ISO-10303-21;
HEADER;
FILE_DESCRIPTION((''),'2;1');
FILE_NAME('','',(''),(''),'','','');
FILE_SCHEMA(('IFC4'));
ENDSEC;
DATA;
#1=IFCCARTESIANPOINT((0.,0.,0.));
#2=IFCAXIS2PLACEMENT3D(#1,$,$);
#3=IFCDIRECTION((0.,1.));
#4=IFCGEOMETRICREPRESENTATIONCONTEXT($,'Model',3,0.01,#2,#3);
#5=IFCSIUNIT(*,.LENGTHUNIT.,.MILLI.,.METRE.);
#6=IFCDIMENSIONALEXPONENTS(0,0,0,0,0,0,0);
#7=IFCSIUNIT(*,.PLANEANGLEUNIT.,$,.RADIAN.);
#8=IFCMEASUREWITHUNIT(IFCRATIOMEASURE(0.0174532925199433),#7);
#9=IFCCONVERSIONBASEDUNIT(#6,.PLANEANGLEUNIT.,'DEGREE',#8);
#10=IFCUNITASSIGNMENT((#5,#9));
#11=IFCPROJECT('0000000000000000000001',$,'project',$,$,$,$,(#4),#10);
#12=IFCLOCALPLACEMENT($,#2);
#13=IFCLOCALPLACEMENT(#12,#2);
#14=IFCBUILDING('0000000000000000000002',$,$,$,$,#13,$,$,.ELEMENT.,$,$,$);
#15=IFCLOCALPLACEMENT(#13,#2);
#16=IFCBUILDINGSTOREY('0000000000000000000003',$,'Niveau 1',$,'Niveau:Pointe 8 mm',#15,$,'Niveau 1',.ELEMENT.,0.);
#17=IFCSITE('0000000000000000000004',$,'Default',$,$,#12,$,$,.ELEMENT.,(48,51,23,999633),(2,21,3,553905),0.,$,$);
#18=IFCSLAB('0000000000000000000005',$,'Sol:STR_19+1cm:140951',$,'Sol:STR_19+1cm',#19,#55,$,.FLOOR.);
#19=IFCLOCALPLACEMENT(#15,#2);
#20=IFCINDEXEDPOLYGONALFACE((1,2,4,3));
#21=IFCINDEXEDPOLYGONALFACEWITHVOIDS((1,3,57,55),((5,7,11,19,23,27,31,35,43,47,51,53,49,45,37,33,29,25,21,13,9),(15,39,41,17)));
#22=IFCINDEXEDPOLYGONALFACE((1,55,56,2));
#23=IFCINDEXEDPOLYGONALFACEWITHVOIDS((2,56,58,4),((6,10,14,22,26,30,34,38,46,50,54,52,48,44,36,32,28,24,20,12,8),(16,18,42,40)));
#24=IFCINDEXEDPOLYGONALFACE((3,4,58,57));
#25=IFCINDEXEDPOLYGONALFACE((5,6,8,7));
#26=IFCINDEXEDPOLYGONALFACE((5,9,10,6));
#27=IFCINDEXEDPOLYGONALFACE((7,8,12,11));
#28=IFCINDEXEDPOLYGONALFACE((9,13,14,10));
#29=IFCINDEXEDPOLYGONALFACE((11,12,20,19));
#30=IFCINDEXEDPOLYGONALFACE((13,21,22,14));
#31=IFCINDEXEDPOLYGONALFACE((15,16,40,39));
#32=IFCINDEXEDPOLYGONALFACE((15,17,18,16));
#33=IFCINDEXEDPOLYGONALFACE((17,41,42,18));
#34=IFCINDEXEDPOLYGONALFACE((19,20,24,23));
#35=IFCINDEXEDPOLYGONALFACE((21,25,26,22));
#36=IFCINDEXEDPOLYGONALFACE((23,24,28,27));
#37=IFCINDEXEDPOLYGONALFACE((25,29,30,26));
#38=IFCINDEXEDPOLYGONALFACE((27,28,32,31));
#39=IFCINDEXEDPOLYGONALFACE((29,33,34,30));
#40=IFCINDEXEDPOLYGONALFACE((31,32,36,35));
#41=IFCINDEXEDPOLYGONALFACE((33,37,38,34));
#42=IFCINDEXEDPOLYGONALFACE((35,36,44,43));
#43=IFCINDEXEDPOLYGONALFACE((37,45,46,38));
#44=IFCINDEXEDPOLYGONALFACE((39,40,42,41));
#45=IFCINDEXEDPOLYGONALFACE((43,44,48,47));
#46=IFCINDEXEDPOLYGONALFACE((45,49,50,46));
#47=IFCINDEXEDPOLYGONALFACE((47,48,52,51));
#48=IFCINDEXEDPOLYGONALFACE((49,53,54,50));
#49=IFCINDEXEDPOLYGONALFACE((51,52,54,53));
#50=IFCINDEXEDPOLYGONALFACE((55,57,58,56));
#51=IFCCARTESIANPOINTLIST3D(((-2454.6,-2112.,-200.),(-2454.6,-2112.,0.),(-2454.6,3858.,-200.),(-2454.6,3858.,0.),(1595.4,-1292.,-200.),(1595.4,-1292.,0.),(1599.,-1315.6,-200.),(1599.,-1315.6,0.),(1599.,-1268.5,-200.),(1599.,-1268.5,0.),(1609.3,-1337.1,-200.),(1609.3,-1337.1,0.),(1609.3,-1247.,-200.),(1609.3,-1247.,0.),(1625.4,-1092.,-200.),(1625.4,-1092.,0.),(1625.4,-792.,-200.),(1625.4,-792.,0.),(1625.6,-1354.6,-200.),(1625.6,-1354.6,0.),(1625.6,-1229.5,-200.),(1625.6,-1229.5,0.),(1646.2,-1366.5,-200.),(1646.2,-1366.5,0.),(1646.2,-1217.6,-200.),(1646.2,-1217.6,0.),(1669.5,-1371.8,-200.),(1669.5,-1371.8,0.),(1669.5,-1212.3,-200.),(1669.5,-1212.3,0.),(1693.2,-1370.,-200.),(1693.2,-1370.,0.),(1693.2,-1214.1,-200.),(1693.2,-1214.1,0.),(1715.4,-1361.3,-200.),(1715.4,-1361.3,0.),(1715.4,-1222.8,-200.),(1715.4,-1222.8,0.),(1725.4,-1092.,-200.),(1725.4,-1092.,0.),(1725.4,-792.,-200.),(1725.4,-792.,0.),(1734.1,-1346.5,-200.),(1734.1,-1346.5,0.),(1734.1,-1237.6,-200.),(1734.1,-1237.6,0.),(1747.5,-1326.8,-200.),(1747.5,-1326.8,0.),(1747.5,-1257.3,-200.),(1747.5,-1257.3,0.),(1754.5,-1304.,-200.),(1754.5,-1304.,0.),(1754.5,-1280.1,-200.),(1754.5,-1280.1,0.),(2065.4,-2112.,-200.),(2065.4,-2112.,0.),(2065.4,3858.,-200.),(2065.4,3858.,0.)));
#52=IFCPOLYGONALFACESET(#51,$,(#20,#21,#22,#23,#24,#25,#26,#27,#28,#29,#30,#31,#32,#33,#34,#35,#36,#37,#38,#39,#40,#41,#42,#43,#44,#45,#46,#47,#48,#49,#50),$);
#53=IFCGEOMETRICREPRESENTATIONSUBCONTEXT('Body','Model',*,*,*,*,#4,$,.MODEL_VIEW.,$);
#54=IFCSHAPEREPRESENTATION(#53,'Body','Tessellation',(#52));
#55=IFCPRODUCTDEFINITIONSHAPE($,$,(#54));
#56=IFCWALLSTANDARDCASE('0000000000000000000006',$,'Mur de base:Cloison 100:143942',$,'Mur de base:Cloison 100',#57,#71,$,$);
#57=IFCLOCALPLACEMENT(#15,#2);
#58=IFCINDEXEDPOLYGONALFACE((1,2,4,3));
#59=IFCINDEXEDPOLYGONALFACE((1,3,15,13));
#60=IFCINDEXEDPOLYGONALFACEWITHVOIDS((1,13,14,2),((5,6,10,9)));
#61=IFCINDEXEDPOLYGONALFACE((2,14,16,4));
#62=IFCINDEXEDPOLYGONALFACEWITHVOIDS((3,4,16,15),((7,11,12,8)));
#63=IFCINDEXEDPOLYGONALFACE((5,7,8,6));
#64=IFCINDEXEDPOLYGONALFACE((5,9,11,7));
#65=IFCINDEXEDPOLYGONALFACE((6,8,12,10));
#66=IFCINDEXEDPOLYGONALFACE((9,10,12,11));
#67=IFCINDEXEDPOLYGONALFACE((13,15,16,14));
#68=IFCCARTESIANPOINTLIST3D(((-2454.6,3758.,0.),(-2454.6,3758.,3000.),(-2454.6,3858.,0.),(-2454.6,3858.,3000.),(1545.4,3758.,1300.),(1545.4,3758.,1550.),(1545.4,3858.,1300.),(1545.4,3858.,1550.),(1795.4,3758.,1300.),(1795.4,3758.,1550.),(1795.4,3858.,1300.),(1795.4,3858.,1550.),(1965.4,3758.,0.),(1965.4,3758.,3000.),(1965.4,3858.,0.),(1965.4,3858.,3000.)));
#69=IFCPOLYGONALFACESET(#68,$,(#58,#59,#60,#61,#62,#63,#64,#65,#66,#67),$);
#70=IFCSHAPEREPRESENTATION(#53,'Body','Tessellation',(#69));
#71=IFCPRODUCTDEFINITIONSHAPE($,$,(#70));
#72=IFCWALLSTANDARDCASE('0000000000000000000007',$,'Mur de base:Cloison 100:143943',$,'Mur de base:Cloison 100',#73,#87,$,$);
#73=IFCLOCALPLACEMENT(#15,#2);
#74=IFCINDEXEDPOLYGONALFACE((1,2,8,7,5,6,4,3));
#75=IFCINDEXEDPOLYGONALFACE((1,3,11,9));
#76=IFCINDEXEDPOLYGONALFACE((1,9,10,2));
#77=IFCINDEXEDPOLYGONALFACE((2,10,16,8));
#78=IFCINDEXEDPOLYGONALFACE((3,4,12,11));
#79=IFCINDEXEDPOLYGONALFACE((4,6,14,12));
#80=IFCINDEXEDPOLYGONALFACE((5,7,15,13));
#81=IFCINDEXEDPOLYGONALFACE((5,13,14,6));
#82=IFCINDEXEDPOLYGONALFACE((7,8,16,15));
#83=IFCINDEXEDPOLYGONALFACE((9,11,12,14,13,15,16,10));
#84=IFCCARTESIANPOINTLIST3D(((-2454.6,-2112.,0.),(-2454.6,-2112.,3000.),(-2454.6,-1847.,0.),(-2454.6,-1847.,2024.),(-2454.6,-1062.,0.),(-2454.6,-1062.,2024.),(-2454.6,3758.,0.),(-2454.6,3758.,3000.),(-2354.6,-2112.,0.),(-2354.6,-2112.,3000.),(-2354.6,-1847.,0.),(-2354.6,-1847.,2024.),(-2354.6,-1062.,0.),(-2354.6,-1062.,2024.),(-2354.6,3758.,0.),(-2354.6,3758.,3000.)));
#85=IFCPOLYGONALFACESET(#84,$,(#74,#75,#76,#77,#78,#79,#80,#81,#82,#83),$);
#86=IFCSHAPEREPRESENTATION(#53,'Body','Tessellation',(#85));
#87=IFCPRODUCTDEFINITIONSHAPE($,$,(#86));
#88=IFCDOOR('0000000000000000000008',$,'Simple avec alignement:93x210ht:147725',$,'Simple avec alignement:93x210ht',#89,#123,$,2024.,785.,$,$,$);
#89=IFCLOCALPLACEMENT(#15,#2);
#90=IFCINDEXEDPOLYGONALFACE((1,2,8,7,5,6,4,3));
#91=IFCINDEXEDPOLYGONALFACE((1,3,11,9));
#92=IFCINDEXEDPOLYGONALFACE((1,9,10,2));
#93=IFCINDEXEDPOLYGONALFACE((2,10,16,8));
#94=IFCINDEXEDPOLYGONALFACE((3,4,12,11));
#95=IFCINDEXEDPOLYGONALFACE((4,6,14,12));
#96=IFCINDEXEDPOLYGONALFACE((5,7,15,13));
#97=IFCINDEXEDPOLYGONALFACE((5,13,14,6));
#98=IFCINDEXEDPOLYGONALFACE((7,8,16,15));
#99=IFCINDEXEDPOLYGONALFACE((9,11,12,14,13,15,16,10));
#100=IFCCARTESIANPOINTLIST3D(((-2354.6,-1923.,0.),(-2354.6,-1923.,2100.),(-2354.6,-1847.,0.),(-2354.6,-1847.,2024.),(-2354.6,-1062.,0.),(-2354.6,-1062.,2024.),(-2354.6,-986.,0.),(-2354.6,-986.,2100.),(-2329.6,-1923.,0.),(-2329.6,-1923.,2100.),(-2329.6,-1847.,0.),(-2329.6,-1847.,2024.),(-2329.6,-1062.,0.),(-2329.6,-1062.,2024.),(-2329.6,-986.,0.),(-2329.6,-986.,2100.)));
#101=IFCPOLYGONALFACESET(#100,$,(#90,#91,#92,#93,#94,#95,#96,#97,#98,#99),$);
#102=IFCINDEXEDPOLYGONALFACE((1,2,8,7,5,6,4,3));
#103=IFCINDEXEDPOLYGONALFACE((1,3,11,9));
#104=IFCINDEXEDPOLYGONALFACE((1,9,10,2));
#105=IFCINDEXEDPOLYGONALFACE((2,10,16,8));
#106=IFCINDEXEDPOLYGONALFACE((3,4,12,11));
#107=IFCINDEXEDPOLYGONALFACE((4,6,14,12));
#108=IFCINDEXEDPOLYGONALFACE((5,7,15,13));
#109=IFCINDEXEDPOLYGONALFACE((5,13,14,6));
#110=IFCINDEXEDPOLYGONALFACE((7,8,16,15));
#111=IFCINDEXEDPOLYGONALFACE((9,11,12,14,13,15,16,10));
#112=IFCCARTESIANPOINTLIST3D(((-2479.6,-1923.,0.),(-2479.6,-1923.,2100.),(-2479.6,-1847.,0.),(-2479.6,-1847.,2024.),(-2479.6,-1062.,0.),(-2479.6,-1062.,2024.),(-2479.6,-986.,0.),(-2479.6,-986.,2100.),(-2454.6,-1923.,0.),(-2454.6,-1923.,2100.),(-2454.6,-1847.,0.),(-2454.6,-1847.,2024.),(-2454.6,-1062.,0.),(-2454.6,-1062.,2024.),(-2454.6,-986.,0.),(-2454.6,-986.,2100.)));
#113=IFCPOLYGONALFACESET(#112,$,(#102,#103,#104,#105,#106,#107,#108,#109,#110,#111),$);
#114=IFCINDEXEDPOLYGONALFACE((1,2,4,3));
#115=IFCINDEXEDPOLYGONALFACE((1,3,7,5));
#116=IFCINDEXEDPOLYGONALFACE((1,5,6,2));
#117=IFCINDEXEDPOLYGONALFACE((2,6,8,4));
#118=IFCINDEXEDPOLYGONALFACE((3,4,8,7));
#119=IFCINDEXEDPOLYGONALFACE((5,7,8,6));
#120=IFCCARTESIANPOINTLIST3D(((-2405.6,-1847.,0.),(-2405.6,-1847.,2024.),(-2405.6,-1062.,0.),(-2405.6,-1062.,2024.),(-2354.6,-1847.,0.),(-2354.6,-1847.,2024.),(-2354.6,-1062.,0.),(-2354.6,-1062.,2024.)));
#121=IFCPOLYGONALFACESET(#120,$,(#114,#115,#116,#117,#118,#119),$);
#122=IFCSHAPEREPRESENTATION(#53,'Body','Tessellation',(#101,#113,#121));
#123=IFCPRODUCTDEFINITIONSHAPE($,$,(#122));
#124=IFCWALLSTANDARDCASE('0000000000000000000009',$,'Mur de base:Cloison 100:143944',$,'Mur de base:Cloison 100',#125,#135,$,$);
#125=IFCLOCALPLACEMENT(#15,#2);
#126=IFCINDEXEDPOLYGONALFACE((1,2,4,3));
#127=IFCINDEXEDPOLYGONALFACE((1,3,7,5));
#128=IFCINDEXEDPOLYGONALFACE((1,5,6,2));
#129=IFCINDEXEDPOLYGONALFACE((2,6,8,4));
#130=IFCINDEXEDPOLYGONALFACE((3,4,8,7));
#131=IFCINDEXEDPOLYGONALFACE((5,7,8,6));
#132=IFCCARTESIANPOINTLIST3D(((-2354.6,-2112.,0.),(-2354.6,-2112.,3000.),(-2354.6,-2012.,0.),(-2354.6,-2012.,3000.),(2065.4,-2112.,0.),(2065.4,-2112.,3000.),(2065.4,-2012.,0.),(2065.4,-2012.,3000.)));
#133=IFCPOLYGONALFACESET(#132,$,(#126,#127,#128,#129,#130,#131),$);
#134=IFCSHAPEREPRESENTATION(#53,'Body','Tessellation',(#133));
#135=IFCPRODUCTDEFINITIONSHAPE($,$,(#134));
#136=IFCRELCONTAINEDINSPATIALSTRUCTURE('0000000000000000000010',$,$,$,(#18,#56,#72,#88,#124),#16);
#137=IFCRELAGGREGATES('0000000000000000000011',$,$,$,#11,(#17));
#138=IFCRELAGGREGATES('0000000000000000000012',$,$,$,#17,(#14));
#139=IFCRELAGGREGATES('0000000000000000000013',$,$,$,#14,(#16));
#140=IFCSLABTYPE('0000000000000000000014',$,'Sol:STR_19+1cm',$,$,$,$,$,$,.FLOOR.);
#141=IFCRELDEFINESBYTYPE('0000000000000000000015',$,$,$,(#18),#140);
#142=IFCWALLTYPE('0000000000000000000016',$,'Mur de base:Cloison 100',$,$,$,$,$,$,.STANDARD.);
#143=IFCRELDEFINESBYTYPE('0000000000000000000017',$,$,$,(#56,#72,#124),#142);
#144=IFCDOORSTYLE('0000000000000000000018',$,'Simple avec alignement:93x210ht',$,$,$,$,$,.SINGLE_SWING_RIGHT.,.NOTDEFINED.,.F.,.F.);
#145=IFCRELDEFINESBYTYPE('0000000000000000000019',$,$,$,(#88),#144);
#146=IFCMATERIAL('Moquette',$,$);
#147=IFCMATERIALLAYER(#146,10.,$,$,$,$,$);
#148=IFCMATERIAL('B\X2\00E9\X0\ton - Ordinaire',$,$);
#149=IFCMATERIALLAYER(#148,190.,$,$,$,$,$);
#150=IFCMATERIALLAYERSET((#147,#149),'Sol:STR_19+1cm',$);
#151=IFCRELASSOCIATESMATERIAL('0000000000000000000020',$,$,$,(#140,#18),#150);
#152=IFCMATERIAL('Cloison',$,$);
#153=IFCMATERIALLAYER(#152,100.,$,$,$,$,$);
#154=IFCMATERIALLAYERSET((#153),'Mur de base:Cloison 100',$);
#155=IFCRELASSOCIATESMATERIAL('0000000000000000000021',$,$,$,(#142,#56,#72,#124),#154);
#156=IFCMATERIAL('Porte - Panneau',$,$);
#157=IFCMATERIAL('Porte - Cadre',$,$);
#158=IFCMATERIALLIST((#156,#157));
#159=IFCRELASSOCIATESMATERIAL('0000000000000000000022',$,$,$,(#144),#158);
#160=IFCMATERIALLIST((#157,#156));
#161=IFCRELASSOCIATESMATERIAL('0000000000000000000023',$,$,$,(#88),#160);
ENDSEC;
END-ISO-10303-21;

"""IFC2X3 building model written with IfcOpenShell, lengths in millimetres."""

from ifc_helpers import new_model, entity, si_unit, converted_unit, direction, frame, frame_2d, origin, origin_2d_with_axis, place, context, subcontext, project, spatial, polyline, rectangle, circle, outline, extrude, source, transform, mapped, material, material_list, layer, layer_set, layer_usage, type_object, type_shapes, element, fill, save


model = new_model("IFC2X3")

# Units and contexts
model_context = context("Model", 3, precision=0.01, world=origin(), true_north=direction((0.0, 1.0)))
body_context = subcontext(model_context, "Body", "Model", "MODEL_VIEW")
ifc_project = project(units=[si_unit("LENGTHUNIT", "METRE", prefix="MILLI"), converted_unit("PLANEANGLEUNIT", "DEGREE", entity("IfcRatioMeasure", 0.0174532925199433), si_unit("PLANEANGLEUNIT", "RADIAN"), dimensions=[0, 0, 0, 0, 0, 0, 0])], contexts=[model_context])

# Site, building, storey
site_placement = place(None, origin())
site = spatial("IfcSite", under=ifc_project, at=site_placement, Name="Default", CompositionType="ELEMENT", RefLatitude=(48, 51, 23, 999633), RefLongitude=(2, 21, 3, 553905), RefElevation=0.0)
building_placement = place(site_placement, origin())
building = spatial("IfcBuilding", under=site, at=building_placement, CompositionType="ELEMENT")
storey_placement = place(building_placement, origin())
storey = spatial("IfcBuildingStorey", under=building, at=storey_placement, Name="Niveau 1", ObjectType="Niveau:Pointe 8 mm", LongName="Niveau 1", CompositionType="ELEMENT", Elevation=0.0)

# Slab, openings
ifc_material_1 = material(Name="Moquette")
ifc_layer_1 = layer(ifc_material_1, 10.0)
ifc_material_2 = material(Name="Béton - Ordinaire")
ifc_layer_2 = layer(ifc_material_2, 190.0)
ifc_layer_set_1 = layer_set([ifc_layer_1, ifc_layer_2], Name="Sol:STR_19+1cm")
ifc_layer_usage_1 = layer_usage(ifc_layer_set_1, "AXIS3", "POSITIVE", 0.0)
slab_type = type_object("IfcSlabType", Name="Sol:STR_19+1cm", PredefinedType="FLOOR", material=ifc_layer_set_1)
slab_placement = place(storey_placement, origin())
slab = element("IfcSlab", 1, at=slab_placement, inside=storey, type_object=slab_type, material=ifc_layer_usage_1, Name="Sol:STR_19+1cm:140951", ObjectType="Sol:STR_19+1cm", PredefinedType="FLOOR", context=body_context, shape_type="SweptSolid", body=[
    extrude(rectangle(XDim=4520.0, YDim=5970.0, at=origin_2d_with_axis()), frame((-194.6, 873.0, 0.0), z_axis=(0.0, 0.0, -1.0), x_axis=(-1.0, 0.0, 0.0)), (0.0, 0.0, 1.0), 200.0),
])
opening_1_placement = place(slab_placement, origin())
element("IfcOpeningElement", 2, at=opening_1_placement, cuts=slab, ObjectType="Opening", context=body_context, shape_type="SweptSolid", body=[
    extrude(circle(Radius=80.0, at=origin_2d_with_axis()), frame((1675.4, -1292.0, -1524.0), z_axis=(0.0, 0.0, 1.0), x_axis=(-1.0, 0.0, 0.0)), (0.0, 0.0, 1.0), 3048.0),
])
opening_2_placement = place(slab_placement, origin())
element("IfcOpeningElement", 3, at=opening_2_placement, cuts=slab, ObjectType="Opening", context=body_context, shape_type="SweptSolid", body=[
    extrude(rectangle(XDim=300.0, YDim=100.0, at=origin_2d_with_axis()), frame((1675.4, -942.0, -1524.0), z_axis=(0.0, 0.0, 1.0), x_axis=(0.0, 1.0, 0.0)), (0.0, 0.0, 1.0), 3048.0),
])

# Wall, opening
ifc_material_3 = material(Name="Cloison")
ifc_layer_3 = layer(ifc_material_3, 100.0)
ifc_layer_set_2 = layer_set([ifc_layer_3], Name="Mur de base:Cloison 100")
ifc_layer_usage_2 = layer_usage(ifc_layer_set_2, "AXIS2", "NEGATIVE", 50.0)
wall_type = type_object("IfcWallType", Name="Mur de base:Cloison 100", PredefinedType="STANDARD", material=ifc_layer_set_2)
wall_1_placement = place(storey_placement, frame((-2454.6, 3808.0, 0.0)))
wall_1 = element("IfcWallStandardCase", 4, at=wall_1_placement, inside=storey, type_object=wall_type, material=ifc_layer_usage_2, Name="Mur de base:Cloison 100:143942", ObjectType="Mur de base:Cloison 100", context=body_context, shape_type="SweptSolid", body=[
    extrude(rectangle(XDim=4420.0, YDim=100.0, at=frame_2d((2210.0, 0.0), x_axis=(-1.0, 0.0))), origin(), (0.0, 0.0, 1.0), 3000.0),
])
opening_3_placement = place(wall_1_placement, origin())
element("IfcOpeningElement", 5, at=opening_3_placement, cuts=wall_1, ObjectType="Opening", context=body_context, shape_type="SweptSolid", body=[
    extrude(rectangle(XDim=250.0, YDim=250.0, at=origin_2d_with_axis()), frame((4125.0, -1574.0, 1425.0), z_axis=(0.0, 1.0, 0.0), x_axis=(0.0, 0.0, 1.0)), (0.0, 0.0, 1.0), 3048.0),
])

# Wall, opening, door
ifc_layer_usage_3 = layer_usage(ifc_layer_set_2, "AXIS2", "NEGATIVE", 50.0)
wall_2_placement = place(storey_placement, frame((-2404.6, -2112.0, 0.0), z_axis=(0.0, 0.0, 1.0), x_axis=(0.0, 1.0, 0.0)))
wall_2 = element("IfcWallStandardCase", 6, at=wall_2_placement, inside=storey, type_object=wall_type, material=ifc_layer_usage_3, Name="Mur de base:Cloison 100:143943", ObjectType="Mur de base:Cloison 100", context=body_context, shape_type="SweptSolid", body=[
    extrude(rectangle(XDim=5870.0, YDim=100.0, at=frame_2d((2935.0, 0.0), x_axis=(-1.0, 0.0))), origin(), (0.0, 0.0, 1.0), 3000.0),
])
opening_4_placement = place(wall_2_placement, frame((1050.0, 50.0, 0.0)))
opening_4 = element("IfcOpeningElement", 7, at=opening_4_placement, cuts=wall_2, ObjectType="Opening", context=body_context, shape_type="SweptSolid", body=[
    extrude(rectangle(XDim=785.0, YDim=2024.0, at=frame_2d((1012.0, 392.5), x_axis=(0.0, 1.0))), frame((0.0, 0.0, 0.0), z_axis=(0.0, -1.0, 0.0), x_axis=(0.0, 0.0, 1.0)), (0.0, 0.0, 1.0), 100.0),
])
ifc_material_4 = material(Name="Porte - Cadre")
ifc_material_5 = material(Name="Porte - Panneau")
ifc_material_list_1 = material_list([ifc_material_4, ifc_material_5])
ifc_material_list_2 = material_list([ifc_material_5, ifc_material_4])
door_style = type_object("IfcDoorStyle", Name="Simple avec alignement:93x210ht", ConstructionType="NOTDEFINED", OperationType="SINGLE_SWING_RIGHT", ParameterTakesPrecedence=False, Sizeable=False, material=ifc_material_list_2)
shared_shape_1 = source(origin(), body_context, "Body", "SweptSolid", [
    extrude(outline(polyline([(-468.5, -1069.0), (468.5, -1069.0), (468.5, 1031.0), (392.5, 1031.0), (392.5, -993.0), (-392.5, -993.0), (-392.5, 1031.0), (-468.5, 1031.0), (-468.5, -1069.0)])), frame((392.5, 100.0, 1031.0), z_axis=(0.0, 1.0, 0.0), x_axis=(1.0, 0.0, 0.0)), (0.0, 0.0, 1.0), 25.0),
    extrude(outline(polyline([(-1069.0, -468.5), (1031.0, -468.5), (1031.0, -392.5), (-993.0, -392.5), (-993.0, 392.5), (1031.0, 392.5), (1031.0, 468.5), (-1069.0, 468.5), (-1069.0, -468.5)])), frame((392.5, -25.0, 1031.0), z_axis=(0.0, 1.0, 0.0), x_axis=(0.0, 0.0, -1.0)), (0.0, 0.0, 1.0), 25.0),
    extrude(rectangle(XDim=51.0, YDim=785.0, at=origin_2d_with_axis()), frame((392.5, 74.5, 0.0), z_axis=(0.0, 0.0, 1.0), x_axis=(0.0, 1.0, 0.0)), (0.0, 0.0, 1.0), 2024.0),
])
type_shapes(door_style, [shared_shape_1])
door_placement = place(opening_4_placement, frame((0.0, 0.0, 0.0), z_axis=(0.0, 0.0, 1.0), x_axis=(-1.0, 0.0, 0.0)))
door = element("IfcDoor", 8, at=door_placement, inside=storey, type_object=door_style, material=ifc_material_list_1, Name="Simple avec alignement:93x210ht:147725", ObjectType="Simple avec alignement:93x210ht", OverallHeight=2024.0, OverallWidth=785.0, context=body_context, shape_type="MappedRepresentation", body=[
    mapped(shared_shape_1, transform((0.0, 0.0, 0.0), scale=1.0)),
])
fill(opening_4, door)

# Wall
ifc_layer_usage_4 = layer_usage(ifc_layer_set_2, "AXIS2", "NEGATIVE", 50.0)
wall_3_placement = place(storey_placement, frame((2065.4, -2062.0, 0.0), z_axis=(0.0, 0.0, 1.0), x_axis=(-1.0, 0.0, 0.0)))
element("IfcWallStandardCase", 9, at=wall_3_placement, inside=storey, type_object=wall_type, material=ifc_layer_usage_4, Name="Mur de base:Cloison 100:143944", ObjectType="Mur de base:Cloison 100", context=body_context, shape_type="SweptSolid", body=[
    extrude(rectangle(XDim=4420.0, YDim=100.0, at=frame_2d((2210.0, 0.0), x_axis=(-1.0, 0.0))), origin(), (0.0, 0.0, 1.0), 3000.0),
])

save(model, "model.ifc")
